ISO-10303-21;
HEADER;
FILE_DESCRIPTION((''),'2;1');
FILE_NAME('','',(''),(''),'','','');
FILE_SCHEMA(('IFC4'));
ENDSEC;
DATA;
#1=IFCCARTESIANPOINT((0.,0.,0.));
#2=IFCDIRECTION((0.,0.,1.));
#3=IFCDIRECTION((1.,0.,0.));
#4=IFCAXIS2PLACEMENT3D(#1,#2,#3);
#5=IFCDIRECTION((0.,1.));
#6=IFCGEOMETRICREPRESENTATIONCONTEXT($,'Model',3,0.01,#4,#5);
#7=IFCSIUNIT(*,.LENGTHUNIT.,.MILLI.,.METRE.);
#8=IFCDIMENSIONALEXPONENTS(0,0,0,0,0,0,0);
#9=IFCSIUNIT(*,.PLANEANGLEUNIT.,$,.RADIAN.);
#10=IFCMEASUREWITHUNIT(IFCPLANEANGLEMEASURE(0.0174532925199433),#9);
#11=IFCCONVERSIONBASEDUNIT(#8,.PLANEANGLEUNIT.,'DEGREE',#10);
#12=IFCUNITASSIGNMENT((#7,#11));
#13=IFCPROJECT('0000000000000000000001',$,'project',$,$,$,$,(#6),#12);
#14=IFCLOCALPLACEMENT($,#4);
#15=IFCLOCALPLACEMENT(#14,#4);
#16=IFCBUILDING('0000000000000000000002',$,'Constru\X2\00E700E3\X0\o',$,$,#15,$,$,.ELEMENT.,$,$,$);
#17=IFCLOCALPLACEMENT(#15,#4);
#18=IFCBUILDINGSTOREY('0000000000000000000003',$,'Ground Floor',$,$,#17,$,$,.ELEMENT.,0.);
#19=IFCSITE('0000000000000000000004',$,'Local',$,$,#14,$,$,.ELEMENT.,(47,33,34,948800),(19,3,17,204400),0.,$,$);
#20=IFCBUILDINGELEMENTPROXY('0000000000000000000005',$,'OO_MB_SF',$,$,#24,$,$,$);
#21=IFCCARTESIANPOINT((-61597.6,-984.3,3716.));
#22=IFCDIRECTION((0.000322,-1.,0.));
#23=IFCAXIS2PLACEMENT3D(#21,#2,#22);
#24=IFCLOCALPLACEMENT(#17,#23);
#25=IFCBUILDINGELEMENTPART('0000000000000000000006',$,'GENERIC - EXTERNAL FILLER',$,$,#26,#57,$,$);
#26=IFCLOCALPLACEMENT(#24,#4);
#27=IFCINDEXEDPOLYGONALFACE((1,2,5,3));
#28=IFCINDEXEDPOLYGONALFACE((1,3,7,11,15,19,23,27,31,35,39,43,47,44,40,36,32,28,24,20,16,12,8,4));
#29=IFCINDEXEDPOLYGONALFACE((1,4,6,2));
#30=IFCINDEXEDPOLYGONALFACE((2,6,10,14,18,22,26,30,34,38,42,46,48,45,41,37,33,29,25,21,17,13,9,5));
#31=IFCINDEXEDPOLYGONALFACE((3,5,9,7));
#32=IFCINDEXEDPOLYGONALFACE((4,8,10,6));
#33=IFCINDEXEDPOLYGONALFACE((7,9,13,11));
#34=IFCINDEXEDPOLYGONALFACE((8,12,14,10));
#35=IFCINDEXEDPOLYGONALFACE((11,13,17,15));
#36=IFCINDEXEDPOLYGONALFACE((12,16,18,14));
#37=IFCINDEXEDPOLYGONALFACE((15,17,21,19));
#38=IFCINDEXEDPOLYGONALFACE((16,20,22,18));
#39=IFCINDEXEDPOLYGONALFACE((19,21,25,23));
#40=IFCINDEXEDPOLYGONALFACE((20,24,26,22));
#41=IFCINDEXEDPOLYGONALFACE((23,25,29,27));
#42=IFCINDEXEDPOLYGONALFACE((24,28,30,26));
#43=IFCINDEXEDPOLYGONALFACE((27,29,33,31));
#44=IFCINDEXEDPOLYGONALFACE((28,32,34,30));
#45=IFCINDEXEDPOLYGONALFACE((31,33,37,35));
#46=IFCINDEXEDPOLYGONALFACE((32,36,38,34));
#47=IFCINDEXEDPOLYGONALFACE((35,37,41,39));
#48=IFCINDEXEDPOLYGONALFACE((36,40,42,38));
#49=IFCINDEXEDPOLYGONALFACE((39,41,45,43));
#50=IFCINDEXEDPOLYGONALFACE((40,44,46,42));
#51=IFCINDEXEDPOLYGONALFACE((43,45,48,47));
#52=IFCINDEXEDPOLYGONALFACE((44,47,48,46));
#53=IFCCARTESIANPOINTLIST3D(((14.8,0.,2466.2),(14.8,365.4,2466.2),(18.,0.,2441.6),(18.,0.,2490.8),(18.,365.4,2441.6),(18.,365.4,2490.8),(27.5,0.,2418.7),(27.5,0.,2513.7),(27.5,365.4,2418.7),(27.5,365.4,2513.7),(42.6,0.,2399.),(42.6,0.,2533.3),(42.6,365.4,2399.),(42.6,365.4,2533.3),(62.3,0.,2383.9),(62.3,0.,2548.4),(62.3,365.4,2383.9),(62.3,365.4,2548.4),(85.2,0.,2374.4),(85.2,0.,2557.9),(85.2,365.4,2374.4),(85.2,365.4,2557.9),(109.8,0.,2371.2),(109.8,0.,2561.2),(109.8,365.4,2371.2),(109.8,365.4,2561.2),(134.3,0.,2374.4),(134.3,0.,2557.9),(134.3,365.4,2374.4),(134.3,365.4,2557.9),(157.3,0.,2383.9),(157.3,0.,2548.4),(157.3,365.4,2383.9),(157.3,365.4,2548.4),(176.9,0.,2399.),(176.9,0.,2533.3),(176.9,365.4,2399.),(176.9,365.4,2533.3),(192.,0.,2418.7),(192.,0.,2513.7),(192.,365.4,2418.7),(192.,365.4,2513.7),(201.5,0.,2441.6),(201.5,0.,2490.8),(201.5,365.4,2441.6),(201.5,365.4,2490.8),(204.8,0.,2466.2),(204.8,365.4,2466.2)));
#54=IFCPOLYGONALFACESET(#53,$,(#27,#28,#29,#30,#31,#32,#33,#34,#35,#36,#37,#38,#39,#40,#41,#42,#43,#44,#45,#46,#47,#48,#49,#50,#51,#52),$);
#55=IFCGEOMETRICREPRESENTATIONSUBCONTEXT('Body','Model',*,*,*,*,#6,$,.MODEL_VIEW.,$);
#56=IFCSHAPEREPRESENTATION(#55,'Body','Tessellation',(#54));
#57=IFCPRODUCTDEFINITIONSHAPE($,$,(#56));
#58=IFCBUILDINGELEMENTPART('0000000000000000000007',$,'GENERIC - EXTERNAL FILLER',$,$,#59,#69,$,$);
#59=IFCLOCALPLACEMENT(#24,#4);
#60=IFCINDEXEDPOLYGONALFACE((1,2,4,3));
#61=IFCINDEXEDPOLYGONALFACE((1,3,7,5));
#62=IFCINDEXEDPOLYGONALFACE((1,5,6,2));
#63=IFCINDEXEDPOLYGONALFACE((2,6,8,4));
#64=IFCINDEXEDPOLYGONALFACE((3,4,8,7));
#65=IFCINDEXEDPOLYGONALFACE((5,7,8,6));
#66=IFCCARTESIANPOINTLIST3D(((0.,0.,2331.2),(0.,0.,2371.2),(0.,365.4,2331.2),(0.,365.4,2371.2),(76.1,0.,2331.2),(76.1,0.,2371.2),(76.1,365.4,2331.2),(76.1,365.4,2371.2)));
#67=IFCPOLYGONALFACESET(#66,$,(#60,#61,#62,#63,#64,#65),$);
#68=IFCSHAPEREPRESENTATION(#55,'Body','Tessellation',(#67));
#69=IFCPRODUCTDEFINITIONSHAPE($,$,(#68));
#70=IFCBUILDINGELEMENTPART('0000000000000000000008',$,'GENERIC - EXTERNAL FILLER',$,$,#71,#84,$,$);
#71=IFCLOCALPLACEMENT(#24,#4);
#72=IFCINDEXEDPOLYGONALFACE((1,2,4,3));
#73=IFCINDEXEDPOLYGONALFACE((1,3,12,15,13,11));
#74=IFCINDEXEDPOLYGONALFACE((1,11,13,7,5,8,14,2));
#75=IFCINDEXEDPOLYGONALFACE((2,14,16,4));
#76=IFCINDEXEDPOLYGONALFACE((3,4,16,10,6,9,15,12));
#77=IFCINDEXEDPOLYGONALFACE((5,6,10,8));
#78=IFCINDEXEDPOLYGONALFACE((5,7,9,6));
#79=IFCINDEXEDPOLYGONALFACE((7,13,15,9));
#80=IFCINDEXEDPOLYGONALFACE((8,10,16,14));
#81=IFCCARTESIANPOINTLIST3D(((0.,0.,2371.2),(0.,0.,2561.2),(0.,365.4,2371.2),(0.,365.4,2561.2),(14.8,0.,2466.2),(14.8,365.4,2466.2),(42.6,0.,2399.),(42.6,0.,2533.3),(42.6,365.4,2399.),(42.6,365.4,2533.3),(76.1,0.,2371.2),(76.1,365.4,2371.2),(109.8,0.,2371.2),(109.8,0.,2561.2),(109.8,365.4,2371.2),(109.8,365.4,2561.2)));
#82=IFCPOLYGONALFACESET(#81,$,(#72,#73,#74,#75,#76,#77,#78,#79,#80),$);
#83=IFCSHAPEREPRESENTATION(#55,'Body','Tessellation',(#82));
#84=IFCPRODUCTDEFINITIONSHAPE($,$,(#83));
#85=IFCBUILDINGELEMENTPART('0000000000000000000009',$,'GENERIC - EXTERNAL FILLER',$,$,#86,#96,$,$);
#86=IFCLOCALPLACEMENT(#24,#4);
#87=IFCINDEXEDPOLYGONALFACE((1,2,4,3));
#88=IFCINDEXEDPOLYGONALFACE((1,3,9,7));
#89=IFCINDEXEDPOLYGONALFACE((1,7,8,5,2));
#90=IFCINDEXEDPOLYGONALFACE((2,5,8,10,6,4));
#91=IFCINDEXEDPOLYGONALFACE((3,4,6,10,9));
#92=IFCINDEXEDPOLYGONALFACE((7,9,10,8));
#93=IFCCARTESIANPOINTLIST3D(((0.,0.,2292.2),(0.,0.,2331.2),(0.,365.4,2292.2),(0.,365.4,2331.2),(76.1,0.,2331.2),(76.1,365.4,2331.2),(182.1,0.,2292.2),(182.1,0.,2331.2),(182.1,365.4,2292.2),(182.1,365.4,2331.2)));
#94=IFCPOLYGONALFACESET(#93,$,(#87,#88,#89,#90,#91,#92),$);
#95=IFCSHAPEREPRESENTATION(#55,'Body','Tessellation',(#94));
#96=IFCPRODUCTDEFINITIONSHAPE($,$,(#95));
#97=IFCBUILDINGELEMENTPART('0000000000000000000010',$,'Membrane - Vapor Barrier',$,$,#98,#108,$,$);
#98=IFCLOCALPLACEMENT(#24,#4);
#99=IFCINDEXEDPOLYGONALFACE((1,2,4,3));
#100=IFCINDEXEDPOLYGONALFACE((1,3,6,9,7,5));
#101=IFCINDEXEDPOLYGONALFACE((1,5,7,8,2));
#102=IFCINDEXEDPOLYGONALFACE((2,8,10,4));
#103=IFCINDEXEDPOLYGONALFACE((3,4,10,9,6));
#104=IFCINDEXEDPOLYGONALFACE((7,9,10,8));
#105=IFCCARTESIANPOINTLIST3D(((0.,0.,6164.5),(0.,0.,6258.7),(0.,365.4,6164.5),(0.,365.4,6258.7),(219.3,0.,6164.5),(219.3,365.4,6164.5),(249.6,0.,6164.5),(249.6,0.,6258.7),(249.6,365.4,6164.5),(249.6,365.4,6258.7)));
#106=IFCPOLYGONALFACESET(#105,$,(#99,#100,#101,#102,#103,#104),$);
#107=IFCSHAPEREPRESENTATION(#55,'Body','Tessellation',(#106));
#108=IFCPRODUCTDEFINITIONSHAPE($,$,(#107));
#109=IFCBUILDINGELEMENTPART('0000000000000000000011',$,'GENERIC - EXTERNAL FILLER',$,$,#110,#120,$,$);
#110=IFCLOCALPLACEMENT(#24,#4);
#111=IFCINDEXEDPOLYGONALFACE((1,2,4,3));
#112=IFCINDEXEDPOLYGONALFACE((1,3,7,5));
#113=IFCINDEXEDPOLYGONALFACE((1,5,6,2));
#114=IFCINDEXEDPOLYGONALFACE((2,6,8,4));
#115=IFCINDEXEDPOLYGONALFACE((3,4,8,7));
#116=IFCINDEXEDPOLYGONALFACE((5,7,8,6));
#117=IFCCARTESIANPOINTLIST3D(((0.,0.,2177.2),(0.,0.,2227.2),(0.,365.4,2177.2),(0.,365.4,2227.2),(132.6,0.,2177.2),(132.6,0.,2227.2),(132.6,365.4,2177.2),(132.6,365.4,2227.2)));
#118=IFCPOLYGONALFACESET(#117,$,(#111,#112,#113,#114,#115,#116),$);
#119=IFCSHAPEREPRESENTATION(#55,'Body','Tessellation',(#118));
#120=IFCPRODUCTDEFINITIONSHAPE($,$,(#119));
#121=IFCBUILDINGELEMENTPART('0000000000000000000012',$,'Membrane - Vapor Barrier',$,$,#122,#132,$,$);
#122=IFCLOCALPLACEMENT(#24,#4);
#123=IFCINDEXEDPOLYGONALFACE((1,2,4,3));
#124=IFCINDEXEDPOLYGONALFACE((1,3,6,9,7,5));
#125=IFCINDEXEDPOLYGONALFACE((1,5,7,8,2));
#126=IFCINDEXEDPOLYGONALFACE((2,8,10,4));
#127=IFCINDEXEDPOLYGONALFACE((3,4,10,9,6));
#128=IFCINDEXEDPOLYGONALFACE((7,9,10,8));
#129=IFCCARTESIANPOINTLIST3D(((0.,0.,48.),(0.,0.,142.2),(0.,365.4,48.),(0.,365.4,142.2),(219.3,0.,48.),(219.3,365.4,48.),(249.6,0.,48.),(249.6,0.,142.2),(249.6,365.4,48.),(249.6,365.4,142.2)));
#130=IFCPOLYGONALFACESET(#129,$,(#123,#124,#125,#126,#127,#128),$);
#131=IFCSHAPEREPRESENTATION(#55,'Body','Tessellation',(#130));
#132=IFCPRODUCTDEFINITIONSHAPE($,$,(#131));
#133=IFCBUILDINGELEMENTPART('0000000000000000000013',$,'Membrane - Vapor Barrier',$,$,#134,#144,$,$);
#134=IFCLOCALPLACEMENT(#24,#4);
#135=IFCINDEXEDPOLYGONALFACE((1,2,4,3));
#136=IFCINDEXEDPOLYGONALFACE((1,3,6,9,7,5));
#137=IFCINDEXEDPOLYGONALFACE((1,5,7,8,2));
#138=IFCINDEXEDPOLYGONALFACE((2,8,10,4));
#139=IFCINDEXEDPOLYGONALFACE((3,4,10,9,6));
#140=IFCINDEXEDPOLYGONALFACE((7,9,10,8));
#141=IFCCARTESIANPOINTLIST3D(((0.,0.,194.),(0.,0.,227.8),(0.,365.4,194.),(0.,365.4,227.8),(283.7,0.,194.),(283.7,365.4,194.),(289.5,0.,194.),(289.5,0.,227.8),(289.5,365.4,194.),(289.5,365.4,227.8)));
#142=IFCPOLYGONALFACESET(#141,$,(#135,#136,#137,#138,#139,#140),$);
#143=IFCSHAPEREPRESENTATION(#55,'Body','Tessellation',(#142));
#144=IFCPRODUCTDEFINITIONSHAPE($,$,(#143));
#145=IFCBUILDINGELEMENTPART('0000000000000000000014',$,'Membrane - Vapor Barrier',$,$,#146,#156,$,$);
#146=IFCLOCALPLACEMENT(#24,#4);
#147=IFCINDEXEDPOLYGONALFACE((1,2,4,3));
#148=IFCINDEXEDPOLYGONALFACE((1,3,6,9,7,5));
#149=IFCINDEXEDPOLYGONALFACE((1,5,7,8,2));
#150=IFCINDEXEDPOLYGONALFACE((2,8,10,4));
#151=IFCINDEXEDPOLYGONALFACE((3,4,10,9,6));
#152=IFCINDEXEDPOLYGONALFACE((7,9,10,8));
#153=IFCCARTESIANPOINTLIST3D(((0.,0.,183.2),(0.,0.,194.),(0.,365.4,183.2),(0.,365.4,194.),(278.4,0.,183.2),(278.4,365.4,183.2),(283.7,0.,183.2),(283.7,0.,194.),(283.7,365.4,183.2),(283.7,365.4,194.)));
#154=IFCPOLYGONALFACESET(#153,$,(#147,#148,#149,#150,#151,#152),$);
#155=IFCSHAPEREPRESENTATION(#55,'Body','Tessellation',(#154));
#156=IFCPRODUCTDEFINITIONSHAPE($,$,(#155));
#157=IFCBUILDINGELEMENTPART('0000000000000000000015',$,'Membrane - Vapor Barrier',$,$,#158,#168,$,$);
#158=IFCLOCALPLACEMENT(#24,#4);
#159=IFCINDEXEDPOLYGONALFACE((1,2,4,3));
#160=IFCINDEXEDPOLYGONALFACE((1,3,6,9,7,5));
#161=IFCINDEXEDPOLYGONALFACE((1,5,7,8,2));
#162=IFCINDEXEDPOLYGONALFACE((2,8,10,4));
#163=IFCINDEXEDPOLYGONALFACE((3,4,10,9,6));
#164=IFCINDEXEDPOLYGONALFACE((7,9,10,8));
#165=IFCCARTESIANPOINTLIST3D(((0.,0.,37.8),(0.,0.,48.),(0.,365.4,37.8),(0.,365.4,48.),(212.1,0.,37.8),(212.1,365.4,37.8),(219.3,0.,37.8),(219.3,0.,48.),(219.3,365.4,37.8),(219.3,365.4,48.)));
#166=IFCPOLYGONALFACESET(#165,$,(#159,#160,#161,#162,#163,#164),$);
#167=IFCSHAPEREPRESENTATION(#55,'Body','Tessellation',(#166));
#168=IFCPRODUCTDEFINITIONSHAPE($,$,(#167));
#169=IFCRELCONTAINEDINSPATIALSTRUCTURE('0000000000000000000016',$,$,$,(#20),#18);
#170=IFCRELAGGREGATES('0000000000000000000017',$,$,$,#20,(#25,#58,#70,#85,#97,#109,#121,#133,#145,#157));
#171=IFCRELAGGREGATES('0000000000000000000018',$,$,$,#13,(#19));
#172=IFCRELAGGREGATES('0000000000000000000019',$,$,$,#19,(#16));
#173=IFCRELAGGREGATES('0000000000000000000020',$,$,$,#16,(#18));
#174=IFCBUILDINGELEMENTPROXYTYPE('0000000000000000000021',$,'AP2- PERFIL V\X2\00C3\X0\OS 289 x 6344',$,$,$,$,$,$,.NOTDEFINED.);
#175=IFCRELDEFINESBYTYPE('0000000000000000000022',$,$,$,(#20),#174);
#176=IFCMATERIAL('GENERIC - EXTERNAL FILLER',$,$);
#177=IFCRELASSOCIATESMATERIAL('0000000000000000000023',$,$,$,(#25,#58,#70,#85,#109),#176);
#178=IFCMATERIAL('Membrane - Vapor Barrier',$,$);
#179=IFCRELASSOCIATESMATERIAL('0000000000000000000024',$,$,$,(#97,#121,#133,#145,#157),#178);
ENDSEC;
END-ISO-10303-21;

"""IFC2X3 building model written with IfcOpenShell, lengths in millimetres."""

from ifc_helpers import new_model, entity, si_unit, converted_unit, point, direction, frame, frame_2d, origin_with_axes, place, context, subcontext, project, spatial, polyline, circle_curve, parameter, trimmed, segment, composite_curve, outline, extrude, material, type_object, element, aggregate, save


model = new_model("IFC2X3")

# Units and contexts
model_context = context("Model", 3, precision=0.01, world=origin_with_axes(), true_north=direction((0.0, 1.0)))
body_context = subcontext(model_context, "Body", "Model", "MODEL_VIEW")
ifc_project = project(units=[si_unit("LENGTHUNIT", "METRE", prefix="MILLI"), converted_unit("PLANEANGLEUNIT", "DEGREE", entity("IfcPlaneAngleMeasure", 0.0174532925199433), si_unit("PLANEANGLEUNIT", "RADIAN"), dimensions=[0, 0, 0, 0, 0, 0, 0])], contexts=[model_context])

# Site, building, storey
site_placement = place(None, origin_with_axes())
site = spatial("IfcSite", under=ifc_project, at=site_placement, Name="Local", CompositionType="ELEMENT", RefLatitude=(47, 33, 34, 948800), RefLongitude=(19, 3, 17, 204400), RefElevation=0.0)
building_placement = place(site_placement, origin_with_axes())
building = spatial("IfcBuilding", under=site, at=building_placement, Name="Construção", CompositionType="ELEMENT")
storey_placement = place(building_placement, origin_with_axes())
storey = spatial("IfcBuildingStorey", under=building, at=storey_placement, Name="Ground Floor", CompositionType="ELEMENT", Elevation=0.0)

# Building element proxy, building element parts
ifc_material_1 = material(Name="Membrane - Vapor Barrier")
building_element_proxy_type_1 = type_object("IfcBuildingElementProxyType", Name="AP2- PERFIL VÃOS 289 x 6344", PredefinedType="NOTDEFINED")
proxy_1_placement = place(storey_placement, frame((-61597.6, -984.3, 3716.0), z_axis=(0.0, 0.0, 1.0), x_axis=(0.000322, -1.0, 0.0)))
proxy_1 = element("IfcBuildingElementProxy", 1, at=proxy_1_placement, inside=storey, type_object=building_element_proxy_type_1, Name="OO_MB_SF")
ifc_material_2 = material(Name="GENERIC - EXTERNAL FILLER")
building_element_part_1_placement = place(proxy_1_placement, origin_with_axes())
building_element_part_1 = element("IfcBuildingElementPart", 2, at=building_element_part_1_placement, material=ifc_material_2, Name="GENERIC - EXTERNAL FILLER", context=body_context, shape_type="SweptSolid", body=[
    extrude(outline(composite_curve([segment(trimmed(circle_curve(frame_2d((109.8, 2466.2), x_axis=(-1.0, 0.0)), 95.0), [point((14.8, 2466.2)), parameter(0.0)], [point((109.8, 2371.2)), parameter(90.0)], True, "CARTESIAN"), True, "CONTINUOUS"), segment(trimmed(circle_curve(frame_2d((109.8, 2466.2), x_axis=(0.0, -1.0)), 95.0), [point((109.8, 2371.2)), parameter(0.0)], [point((204.8, 2466.2)), parameter(90.0)], True, "CARTESIAN"), True, "CONTINUOUS"), segment(trimmed(circle_curve(frame_2d((109.8, 2466.2), x_axis=(1.0, 0.0)), 95.0), [point((204.8, 2466.2)), parameter(0.0)], [point((109.8, 2561.2)), parameter(90.0)], True, "CARTESIAN"), True, "CONTINUOUS"), segment(trimmed(circle_curve(frame_2d((109.8, 2466.2), x_axis=(0.0, 1.0)), 95.0), [point((109.8, 2561.2)), parameter(0.0)], [point((14.8, 2466.2)), parameter(90.0)], True, "CARTESIAN"), True, "CONTINUOUS")], self_intersect=False)), frame((0.0, 365.4, 0.0), z_axis=(0.0, -1.0, 0.0), x_axis=(1.0, 0.0, 0.0)), (0.0, 0.0, 1.0), 365.4),
])
building_element_part_2_placement = place(proxy_1_placement, origin_with_axes())
building_element_part_2 = element("IfcBuildingElementPart", 3, at=building_element_part_2_placement, material=ifc_material_2, Name="GENERIC - EXTERNAL FILLER", context=body_context, shape_type="SweptSolid", body=[
    extrude(outline(polyline([(76.1, 2371.2), (0.0, 2371.2), (0.0, 2331.2), (76.1, 2331.2), (76.1, 2371.2)])), frame((0.0, 365.4, 0.0), z_axis=(0.0, -1.0, 0.0), x_axis=(1.0, 0.0, 0.0)), (0.0, 0.0, 1.0), 365.4),
])
building_element_part_3_placement = place(proxy_1_placement, origin_with_axes())
building_element_part_3 = element("IfcBuildingElementPart", 4, at=building_element_part_3_placement, material=ifc_material_2, Name="GENERIC - EXTERNAL FILLER", context=body_context, shape_type="SweptSolid", body=[
    extrude(outline(composite_curve([segment(polyline([(109.8, 2561.2), (0.0, 2561.2), (0.0, 2371.2), (76.1, 2371.2), (109.8, 2371.2)]), True, "CONTINUOUS"), segment(trimmed(circle_curve(frame_2d((109.8, 2466.2), x_axis=(-1.0, 0.0)), 95.0), [point((109.8, 2371.2)), parameter(90.0)], [point((14.8, 2466.2)), parameter(0.0)], False, "CARTESIAN"), True, "CONTINUOUS"), segment(trimmed(circle_curve(frame_2d((109.8, 2466.2), x_axis=(0.0, 1.0)), 95.0), [point((14.8, 2466.2)), parameter(90.0)], [point((109.8, 2561.2)), parameter(0.0)], False, "CARTESIAN"), True, "CONTINUOUS")], self_intersect=False)), frame((0.0, 365.4, 0.0), z_axis=(0.0, -1.0, 0.0), x_axis=(1.0, 0.0, 0.0)), (0.0, 0.0, 1.0), 365.4),
])
building_element_part_4_placement = place(proxy_1_placement, origin_with_axes())
building_element_part_4 = element("IfcBuildingElementPart", 5, at=building_element_part_4_placement, material=ifc_material_2, Name="GENERIC - EXTERNAL FILLER", context=body_context, shape_type="SweptSolid", body=[
    extrude(outline(polyline([(0.0, 2331.2), (0.0, 2292.2), (182.1, 2292.2), (182.1, 2331.2), (76.1, 2331.2), (0.0, 2331.2)])), frame((0.0, 365.4, 0.0), z_axis=(0.0, -1.0, 0.0), x_axis=(1.0, 0.0, 0.0)), (0.0, 0.0, 1.0), 365.4),
])
building_element_part_5_placement = place(proxy_1_placement, origin_with_axes())
building_element_part_5 = element("IfcBuildingElementPart", 6, at=building_element_part_5_placement, material=ifc_material_1, Name="Membrane - Vapor Barrier", context=body_context, shape_type="SweptSolid", body=[
    extrude(outline(polyline([(249.6, 6258.7), (0.0, 6258.7), (0.0, 6164.5), (219.3, 6164.5), (249.6, 6164.5), (249.6, 6258.7)])), frame((0.0, 365.4, 0.0), z_axis=(0.0, -1.0, 0.0), x_axis=(1.0, 0.0, 0.0)), (0.0, 0.0, 1.0), 365.4),
])
building_element_part_6_placement = place(proxy_1_placement, origin_with_axes())
building_element_part_6 = element("IfcBuildingElementPart", 7, at=building_element_part_6_placement, material=ifc_material_2, Name="GENERIC - EXTERNAL FILLER", context=body_context, shape_type="SweptSolid", body=[
    extrude(outline(polyline([(0.0, 2227.2), (0.0, 2177.2), (132.6, 2177.2), (132.6, 2227.2), (0.0, 2227.2)])), frame((0.0, 365.4, 0.0), z_axis=(0.0, -1.0, 0.0), x_axis=(1.0, 0.0, 0.0)), (0.0, 0.0, 1.0), 365.4),
])
building_element_part_7_placement = place(proxy_1_placement, origin_with_axes())
building_element_part_7 = element("IfcBuildingElementPart", 8, at=building_element_part_7_placement, material=ifc_material_1, Name="Membrane - Vapor Barrier", context=body_context, shape_type="SweptSolid", body=[
    extrude(outline(polyline([(249.6, 142.2), (0.0, 142.2), (0.0, 48.0), (219.3, 48.0), (249.6, 48.0), (249.6, 142.2)])), frame((0.0, 365.4, 0.0), z_axis=(0.0, -1.0, 0.0), x_axis=(1.0, 0.0, 0.0)), (0.0, 0.0, 1.0), 365.4),
])
building_element_part_8_placement = place(proxy_1_placement, origin_with_axes())
building_element_part_8 = element("IfcBuildingElementPart", 9, at=building_element_part_8_placement, material=ifc_material_1, Name="Membrane - Vapor Barrier", context=body_context, shape_type="SweptSolid", body=[
    extrude(outline(polyline([(0.0, 194.0), (283.7, 194.0), (289.5, 194.0), (289.5, 227.8), (0.0, 227.8), (0.0, 194.0)])), frame((0.0, 365.4, 0.0), z_axis=(0.0, -1.0, 0.0), x_axis=(1.0, 0.0, 0.0)), (0.0, 0.0, 1.0), 365.4),
])
building_element_part_9_placement = place(proxy_1_placement, origin_with_axes())
building_element_part_9 = element("IfcBuildingElementPart", 10, at=building_element_part_9_placement, material=ifc_material_1, Name="Membrane - Vapor Barrier", context=body_context, shape_type="SweptSolid", body=[
    extrude(outline(polyline([(0.0, 183.2), (278.4, 183.2), (283.7, 183.2), (283.7, 194.0), (0.0, 194.0), (0.0, 183.2)])), frame((0.0, 365.4, 0.0), z_axis=(0.0, -1.0, 0.0), x_axis=(1.0, 0.0, 0.0)), (0.0, 0.0, 1.0), 365.4),
])
building_element_part_10_placement = place(proxy_1_placement, origin_with_axes())
building_element_part_10 = element("IfcBuildingElementPart", 11, at=building_element_part_10_placement, material=ifc_material_1, Name="Membrane - Vapor Barrier", context=body_context, shape_type="SweptSolid", body=[
    extrude(outline(polyline([(0.0, 37.8), (212.1, 37.8), (219.3, 37.8), (219.3, 48.0), (0.0, 48.0), (0.0, 37.8)])), frame((0.0, 365.4, 0.0), z_axis=(0.0, -1.0, 0.0), x_axis=(1.0, 0.0, 0.0)), (0.0, 0.0, 1.0), 365.4),
])
aggregate(proxy_1, [building_element_part_1, building_element_part_2, building_element_part_3, building_element_part_4, building_element_part_5, building_element_part_6, building_element_part_7, building_element_part_8, building_element_part_9, building_element_part_10])

save(model, "model.ifc")
